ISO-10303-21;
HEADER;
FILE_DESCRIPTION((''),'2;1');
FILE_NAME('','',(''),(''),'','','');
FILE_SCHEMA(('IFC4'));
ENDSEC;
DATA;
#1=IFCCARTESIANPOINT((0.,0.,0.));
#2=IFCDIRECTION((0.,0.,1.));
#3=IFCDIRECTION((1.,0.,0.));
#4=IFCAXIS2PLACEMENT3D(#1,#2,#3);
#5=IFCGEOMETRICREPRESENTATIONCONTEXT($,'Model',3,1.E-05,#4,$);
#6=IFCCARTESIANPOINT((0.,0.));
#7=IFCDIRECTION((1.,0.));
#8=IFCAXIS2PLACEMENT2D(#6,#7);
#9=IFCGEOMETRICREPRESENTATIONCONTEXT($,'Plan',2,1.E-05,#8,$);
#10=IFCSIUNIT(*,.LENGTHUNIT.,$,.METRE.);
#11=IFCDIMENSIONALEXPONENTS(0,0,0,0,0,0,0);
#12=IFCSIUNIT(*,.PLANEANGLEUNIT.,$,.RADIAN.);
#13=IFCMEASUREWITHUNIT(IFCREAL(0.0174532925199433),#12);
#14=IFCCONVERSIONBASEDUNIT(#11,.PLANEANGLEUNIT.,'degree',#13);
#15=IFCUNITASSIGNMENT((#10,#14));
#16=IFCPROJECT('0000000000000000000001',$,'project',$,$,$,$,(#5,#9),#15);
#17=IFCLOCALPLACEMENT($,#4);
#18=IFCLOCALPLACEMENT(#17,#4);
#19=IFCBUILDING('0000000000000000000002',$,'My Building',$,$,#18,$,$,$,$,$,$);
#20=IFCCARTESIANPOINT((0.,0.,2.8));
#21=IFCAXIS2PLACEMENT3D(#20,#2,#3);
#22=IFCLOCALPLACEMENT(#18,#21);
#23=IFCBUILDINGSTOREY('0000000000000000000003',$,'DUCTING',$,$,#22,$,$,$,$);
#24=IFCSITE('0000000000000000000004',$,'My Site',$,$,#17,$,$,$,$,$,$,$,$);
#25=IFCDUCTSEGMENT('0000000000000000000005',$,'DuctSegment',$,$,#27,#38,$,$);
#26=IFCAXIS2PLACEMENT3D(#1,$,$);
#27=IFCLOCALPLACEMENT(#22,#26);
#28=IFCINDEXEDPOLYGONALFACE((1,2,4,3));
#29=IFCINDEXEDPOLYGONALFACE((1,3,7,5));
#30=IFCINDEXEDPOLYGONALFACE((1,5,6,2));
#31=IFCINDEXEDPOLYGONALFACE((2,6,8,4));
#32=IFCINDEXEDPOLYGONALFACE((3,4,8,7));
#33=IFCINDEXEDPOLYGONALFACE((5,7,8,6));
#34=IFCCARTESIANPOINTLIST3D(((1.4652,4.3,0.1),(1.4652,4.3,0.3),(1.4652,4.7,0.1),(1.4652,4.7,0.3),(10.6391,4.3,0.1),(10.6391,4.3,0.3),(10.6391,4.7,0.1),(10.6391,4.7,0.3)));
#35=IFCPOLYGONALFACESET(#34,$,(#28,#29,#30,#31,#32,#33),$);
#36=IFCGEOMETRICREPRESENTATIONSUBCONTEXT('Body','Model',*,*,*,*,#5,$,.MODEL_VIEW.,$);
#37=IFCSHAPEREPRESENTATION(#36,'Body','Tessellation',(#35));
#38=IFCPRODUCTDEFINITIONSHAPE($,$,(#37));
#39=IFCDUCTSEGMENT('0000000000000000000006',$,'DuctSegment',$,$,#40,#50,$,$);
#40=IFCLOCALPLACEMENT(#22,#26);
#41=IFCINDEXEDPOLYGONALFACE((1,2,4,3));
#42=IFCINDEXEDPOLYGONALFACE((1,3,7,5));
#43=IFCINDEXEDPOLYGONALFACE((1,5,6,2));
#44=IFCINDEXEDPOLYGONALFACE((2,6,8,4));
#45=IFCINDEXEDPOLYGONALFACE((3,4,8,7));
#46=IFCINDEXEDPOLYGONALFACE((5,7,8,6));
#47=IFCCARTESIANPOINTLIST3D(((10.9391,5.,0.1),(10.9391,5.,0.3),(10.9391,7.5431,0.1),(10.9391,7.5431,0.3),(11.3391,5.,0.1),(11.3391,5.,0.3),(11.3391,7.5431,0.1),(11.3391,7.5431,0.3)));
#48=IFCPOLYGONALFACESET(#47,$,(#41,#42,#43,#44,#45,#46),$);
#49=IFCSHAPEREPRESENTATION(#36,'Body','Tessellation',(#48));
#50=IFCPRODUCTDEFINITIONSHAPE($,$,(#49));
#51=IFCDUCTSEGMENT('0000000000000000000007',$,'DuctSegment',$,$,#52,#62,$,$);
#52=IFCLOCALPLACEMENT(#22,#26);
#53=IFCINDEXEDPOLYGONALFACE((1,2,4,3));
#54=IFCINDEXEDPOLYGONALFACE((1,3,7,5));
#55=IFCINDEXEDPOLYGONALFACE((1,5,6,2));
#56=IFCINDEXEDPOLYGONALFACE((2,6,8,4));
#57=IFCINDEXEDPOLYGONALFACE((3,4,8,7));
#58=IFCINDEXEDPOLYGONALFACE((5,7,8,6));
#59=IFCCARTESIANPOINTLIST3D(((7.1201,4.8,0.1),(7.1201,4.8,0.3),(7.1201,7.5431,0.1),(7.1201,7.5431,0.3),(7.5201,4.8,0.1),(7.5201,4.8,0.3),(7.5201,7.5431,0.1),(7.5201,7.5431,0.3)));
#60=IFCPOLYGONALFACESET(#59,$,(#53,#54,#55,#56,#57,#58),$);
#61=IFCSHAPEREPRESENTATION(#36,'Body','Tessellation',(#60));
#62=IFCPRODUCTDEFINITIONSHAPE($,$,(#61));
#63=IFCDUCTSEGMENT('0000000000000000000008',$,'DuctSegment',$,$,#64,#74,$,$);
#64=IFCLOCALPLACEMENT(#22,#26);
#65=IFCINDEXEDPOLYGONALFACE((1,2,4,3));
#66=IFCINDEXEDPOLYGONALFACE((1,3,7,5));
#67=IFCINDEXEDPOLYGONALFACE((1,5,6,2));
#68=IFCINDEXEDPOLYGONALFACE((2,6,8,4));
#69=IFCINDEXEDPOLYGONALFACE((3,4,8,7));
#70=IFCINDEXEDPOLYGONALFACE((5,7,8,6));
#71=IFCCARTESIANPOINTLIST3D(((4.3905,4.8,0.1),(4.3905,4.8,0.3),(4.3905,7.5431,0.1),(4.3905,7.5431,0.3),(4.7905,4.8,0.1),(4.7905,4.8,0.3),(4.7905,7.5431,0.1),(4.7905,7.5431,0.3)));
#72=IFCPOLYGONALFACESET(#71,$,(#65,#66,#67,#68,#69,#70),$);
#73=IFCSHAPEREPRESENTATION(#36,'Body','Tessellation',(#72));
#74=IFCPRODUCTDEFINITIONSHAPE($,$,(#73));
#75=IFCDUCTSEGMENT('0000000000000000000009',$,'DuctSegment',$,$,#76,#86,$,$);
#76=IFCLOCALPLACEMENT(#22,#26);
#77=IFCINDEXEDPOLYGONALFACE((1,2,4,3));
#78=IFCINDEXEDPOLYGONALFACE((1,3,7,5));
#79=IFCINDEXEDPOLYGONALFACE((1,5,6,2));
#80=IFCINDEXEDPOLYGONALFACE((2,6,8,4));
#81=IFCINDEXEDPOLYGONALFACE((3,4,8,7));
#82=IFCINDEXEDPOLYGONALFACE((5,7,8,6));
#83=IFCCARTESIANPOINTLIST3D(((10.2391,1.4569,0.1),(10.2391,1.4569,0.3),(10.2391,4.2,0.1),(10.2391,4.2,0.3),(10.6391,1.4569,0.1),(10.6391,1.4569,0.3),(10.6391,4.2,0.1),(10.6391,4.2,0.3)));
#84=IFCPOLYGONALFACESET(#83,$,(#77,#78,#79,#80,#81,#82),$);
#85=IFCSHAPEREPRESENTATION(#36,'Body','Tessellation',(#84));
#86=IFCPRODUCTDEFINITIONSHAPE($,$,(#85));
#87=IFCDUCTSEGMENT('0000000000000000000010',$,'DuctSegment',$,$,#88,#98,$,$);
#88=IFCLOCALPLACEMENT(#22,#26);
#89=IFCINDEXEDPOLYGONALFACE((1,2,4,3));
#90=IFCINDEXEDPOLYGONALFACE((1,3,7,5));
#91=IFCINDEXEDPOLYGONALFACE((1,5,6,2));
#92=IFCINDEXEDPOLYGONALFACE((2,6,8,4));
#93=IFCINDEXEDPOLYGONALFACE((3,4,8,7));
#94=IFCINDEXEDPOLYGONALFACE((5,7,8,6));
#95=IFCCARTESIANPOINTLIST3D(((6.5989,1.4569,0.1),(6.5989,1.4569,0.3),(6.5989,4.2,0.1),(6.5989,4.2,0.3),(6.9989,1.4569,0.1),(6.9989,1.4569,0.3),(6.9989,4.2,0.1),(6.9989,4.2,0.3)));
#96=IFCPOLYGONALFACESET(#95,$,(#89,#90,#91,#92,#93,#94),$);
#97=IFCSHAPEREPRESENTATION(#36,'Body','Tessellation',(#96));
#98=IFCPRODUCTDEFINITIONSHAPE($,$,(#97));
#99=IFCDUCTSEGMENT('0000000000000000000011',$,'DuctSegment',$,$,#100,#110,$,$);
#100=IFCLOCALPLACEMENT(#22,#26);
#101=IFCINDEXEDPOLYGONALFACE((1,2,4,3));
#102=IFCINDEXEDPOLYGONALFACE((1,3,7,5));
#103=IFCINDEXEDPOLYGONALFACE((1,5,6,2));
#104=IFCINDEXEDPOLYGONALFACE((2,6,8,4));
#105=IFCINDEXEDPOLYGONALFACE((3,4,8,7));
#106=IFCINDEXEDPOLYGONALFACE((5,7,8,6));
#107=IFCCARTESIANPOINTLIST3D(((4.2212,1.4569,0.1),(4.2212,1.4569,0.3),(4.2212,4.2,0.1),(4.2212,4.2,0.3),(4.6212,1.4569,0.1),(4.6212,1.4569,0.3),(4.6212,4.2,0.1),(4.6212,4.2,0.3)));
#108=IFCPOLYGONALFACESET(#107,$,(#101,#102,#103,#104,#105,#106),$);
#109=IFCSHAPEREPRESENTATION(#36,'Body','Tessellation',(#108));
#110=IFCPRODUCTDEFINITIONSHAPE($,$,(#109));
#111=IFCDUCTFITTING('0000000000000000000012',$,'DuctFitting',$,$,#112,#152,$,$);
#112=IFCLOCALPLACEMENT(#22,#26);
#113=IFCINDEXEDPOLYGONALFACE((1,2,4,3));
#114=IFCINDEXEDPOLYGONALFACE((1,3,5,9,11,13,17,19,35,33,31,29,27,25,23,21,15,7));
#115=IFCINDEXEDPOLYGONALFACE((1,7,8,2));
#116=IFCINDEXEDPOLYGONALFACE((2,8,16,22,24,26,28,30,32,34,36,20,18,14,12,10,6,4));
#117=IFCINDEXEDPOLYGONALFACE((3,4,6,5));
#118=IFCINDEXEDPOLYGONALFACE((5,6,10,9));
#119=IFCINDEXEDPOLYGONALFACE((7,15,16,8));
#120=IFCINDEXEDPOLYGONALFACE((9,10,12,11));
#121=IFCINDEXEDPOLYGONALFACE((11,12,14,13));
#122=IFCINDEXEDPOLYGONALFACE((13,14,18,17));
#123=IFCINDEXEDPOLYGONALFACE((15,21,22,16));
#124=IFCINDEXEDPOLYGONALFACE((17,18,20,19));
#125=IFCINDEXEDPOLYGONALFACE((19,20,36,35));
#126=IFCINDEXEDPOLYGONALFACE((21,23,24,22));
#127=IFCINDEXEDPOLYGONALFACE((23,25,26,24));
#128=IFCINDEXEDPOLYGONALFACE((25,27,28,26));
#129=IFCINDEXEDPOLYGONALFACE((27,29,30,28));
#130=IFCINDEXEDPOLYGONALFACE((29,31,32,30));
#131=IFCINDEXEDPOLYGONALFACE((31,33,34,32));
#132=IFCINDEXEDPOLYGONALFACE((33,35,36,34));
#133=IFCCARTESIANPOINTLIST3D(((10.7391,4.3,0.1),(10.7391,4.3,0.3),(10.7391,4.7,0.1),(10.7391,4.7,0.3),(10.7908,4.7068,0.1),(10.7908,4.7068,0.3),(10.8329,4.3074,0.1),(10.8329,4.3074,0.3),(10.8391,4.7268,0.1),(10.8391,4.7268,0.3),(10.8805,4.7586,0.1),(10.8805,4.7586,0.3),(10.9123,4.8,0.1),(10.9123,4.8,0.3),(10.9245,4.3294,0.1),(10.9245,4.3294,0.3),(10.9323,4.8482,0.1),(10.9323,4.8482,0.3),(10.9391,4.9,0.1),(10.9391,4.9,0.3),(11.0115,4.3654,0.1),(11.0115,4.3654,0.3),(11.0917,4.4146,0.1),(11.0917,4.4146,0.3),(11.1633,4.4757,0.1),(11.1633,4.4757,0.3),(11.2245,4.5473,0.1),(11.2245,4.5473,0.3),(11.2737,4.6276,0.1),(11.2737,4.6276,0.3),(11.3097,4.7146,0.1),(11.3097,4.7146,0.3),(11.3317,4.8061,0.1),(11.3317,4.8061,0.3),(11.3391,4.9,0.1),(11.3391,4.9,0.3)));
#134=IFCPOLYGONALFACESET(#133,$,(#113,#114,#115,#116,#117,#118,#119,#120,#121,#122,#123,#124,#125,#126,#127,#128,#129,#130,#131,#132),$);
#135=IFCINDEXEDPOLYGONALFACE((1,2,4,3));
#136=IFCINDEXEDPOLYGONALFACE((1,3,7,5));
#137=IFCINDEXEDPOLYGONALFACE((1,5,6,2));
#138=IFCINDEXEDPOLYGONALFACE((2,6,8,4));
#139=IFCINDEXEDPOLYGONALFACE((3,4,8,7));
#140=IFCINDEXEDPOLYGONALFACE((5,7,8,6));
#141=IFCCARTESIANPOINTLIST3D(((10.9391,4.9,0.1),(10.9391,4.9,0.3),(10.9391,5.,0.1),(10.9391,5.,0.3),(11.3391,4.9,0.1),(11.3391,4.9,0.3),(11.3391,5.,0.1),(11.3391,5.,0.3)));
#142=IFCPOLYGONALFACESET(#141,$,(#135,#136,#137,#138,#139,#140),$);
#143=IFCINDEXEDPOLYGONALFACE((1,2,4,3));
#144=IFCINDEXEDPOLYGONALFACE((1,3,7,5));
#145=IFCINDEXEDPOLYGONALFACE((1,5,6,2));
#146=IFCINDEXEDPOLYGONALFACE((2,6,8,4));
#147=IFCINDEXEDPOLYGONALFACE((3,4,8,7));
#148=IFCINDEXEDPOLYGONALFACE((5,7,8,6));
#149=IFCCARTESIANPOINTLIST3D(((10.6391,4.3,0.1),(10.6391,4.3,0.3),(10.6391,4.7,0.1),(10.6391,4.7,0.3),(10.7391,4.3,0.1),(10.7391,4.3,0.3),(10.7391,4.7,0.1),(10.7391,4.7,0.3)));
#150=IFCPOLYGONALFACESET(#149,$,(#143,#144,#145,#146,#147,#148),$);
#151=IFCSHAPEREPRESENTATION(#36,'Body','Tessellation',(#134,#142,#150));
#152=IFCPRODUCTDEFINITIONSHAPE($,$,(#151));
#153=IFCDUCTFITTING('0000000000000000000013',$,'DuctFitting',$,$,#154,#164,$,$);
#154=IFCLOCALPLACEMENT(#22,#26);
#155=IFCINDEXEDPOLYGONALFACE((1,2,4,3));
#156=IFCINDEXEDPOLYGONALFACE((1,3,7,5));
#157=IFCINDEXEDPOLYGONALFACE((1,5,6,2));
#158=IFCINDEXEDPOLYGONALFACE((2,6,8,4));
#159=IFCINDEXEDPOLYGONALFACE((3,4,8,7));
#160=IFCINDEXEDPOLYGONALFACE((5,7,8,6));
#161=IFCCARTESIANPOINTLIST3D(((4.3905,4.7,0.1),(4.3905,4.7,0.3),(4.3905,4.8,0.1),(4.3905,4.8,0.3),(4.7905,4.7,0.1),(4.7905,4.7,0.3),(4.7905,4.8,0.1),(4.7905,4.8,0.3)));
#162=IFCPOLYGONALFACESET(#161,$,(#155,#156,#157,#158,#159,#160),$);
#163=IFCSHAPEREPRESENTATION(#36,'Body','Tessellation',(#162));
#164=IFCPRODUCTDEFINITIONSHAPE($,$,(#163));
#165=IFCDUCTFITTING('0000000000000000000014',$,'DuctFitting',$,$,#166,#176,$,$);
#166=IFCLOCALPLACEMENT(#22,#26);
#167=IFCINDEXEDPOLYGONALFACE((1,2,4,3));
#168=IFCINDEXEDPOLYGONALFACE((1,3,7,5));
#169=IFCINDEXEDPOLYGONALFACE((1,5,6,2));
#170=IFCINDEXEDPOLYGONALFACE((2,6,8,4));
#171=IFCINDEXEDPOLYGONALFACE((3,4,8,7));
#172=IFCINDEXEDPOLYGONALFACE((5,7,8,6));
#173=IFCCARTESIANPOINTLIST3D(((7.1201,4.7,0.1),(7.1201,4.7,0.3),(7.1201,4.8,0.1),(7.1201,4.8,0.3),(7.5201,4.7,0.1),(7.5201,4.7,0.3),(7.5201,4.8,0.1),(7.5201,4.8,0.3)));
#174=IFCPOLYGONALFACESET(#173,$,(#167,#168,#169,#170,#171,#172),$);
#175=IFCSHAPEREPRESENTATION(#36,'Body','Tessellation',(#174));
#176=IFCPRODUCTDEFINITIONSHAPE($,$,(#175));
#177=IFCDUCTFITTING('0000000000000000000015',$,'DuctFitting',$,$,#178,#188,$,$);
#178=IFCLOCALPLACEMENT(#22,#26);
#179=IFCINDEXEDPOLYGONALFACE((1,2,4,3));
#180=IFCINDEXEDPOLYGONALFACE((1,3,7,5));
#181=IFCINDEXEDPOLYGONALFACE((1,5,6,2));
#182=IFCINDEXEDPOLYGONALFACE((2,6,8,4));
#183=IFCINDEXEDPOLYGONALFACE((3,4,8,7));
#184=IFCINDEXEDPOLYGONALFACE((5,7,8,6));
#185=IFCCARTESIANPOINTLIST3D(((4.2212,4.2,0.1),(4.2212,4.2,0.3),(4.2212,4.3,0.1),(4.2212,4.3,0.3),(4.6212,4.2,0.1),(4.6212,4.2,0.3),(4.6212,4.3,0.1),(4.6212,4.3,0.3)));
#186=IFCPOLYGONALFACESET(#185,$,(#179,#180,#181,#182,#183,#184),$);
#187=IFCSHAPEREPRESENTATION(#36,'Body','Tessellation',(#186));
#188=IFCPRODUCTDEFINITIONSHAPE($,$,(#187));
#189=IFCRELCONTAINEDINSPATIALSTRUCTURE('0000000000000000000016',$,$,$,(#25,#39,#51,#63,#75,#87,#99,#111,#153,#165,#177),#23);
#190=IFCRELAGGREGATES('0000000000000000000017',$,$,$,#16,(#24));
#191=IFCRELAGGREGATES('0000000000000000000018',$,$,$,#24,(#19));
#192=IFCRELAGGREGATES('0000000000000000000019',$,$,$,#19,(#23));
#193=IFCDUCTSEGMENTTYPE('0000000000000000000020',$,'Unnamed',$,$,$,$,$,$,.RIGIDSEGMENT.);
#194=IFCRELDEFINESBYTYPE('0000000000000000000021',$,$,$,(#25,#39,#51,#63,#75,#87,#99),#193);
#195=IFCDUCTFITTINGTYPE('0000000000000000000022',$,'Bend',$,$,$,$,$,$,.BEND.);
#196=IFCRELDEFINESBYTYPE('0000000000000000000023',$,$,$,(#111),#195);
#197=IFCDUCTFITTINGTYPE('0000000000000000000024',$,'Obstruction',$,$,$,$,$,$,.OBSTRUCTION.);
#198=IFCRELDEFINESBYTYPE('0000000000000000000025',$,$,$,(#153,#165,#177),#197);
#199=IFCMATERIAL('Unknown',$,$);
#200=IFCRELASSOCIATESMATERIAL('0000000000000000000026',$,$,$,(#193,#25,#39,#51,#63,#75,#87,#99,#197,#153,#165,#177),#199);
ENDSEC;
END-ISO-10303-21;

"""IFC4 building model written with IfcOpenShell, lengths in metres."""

from ifc_helpers import new_model, entity, si_unit, converted_unit, frame, origin_with_axes, origin_2d_with_axis, place, context, subcontext, project, spatial, line, arc, indexed_curve, rectangle, outline, extrude, source, transform, mapped, material, material_profile, profile_set, profile_usage, type_object, type_shapes, element, save


model = new_model("IFC4")

# Units and contexts
model_context = context("Model", 3, precision=1e-05, world=origin_with_axes())
plan_context = context("Plan", 2, precision=1e-05, world=origin_2d_with_axis())
body_context = subcontext(model_context, "Body", "Model", "MODEL_VIEW")
ifc_project = project(units=[si_unit("LENGTHUNIT", "METRE"), converted_unit("PLANEANGLEUNIT", "degree", entity("IfcReal", 0.0174532925199433), si_unit("PLANEANGLEUNIT", "RADIAN"), dimensions=[0, 0, 0, 0, 0, 0, 0])], contexts=[model_context, plan_context])

# Site, building, storey
site_placement = place(None, origin_with_axes())
site = spatial("IfcSite", under=ifc_project, at=site_placement, Name="My Site")
building_placement = place(site_placement, origin_with_axes())
building = spatial("IfcBuilding", under=site, at=building_placement, Name="My Building")
storey_placement = place(building_placement, frame((0.0, 0.0, 2.8), z_axis=(0.0, 0.0, 1.0), x_axis=(1.0, 0.0, 0.0)))
storey = spatial("IfcBuildingStorey", under=building, at=storey_placement, Name="DUCTING")

# Duct segments
ifc_material = material(Name="Unknown")
ifc_material_profile_1 = material_profile(ifc_material, rectangle(XDim=0.4, YDim=0.2))
ifc_profile_set_1 = profile_set([ifc_material_profile_1])
ifc_profile_usage_1 = profile_usage(ifc_profile_set_1, cardinal=5)
duct_segment_type = type_object("IfcDuctSegmentType", Name="Unnamed", PredefinedType="RIGIDSEGMENT", material=ifc_profile_set_1)
duct_segment_1_placement = place(storey_placement, frame((1.4652, 4.5, 0.2), z_axis=(1.0, 0.0, 0.0), x_axis=(0.0, 1.0, 0.0)))
element("IfcDuctSegment", 1, at=duct_segment_1_placement, inside=storey, type_object=duct_segment_type, material=ifc_profile_usage_1, Name="DuctSegment", context=body_context, shape_type="SweptSolid", body=[
    extrude(rectangle(XDim=0.4, YDim=0.2), origin_with_axes(), (0.0, 0.0, 1.0), 9.1739),
])
ifc_profile_usage_2 = profile_usage(ifc_profile_set_1, cardinal=5)
duct_segment_2_placement = place(storey_placement, frame((11.1391, 5.0, 0.2), z_axis=(0.0, 1.0, 0.0), x_axis=(-1.0, 0.0, 0.0)))
element("IfcDuctSegment", 2, at=duct_segment_2_placement, inside=storey, type_object=duct_segment_type, material=ifc_profile_usage_2, Name="DuctSegment", context=body_context, shape_type="SweptSolid", body=[
    extrude(rectangle(XDim=0.4, YDim=0.2), origin_with_axes(), (0.0, 0.0, 1.0), 2.5431),
])
ifc_profile_usage_3 = profile_usage(ifc_profile_set_1, cardinal=5)
duct_segment_3_placement = place(storey_placement, frame((7.3201, 4.8, 0.2), z_axis=(0.0, 1.0, 0.0), x_axis=(-1.0, 0.0, 0.0)))
element("IfcDuctSegment", 3, at=duct_segment_3_placement, inside=storey, type_object=duct_segment_type, material=ifc_profile_usage_3, Name="DuctSegment", context=body_context, shape_type="SweptSolid", body=[
    extrude(rectangle(XDim=0.4, YDim=0.2), origin_with_axes(), (0.0, 0.0, 1.0), 2.7431),
])
ifc_profile_usage_4 = profile_usage(ifc_profile_set_1, cardinal=5)
duct_segment_4_placement = place(storey_placement, frame((4.5905, 4.8, 0.2), z_axis=(0.0, 1.0, 0.0), x_axis=(-1.0, 0.0, 0.0)))
element("IfcDuctSegment", 4, at=duct_segment_4_placement, inside=storey, type_object=duct_segment_type, material=ifc_profile_usage_4, Name="DuctSegment", context=body_context, shape_type="SweptSolid", body=[
    extrude(rectangle(XDim=0.4, YDim=0.2), origin_with_axes(), (0.0, 0.0, 1.0), 2.7431),
])
ifc_profile_usage_5 = profile_usage(ifc_profile_set_1, cardinal=5)
duct_segment_5_placement = place(storey_placement, frame((10.4391, 4.2, 0.2), z_axis=(0.0, -1.0, 0.0), x_axis=(1.0, 0.0, 0.0)))
element("IfcDuctSegment", 5, at=duct_segment_5_placement, inside=storey, type_object=duct_segment_type, material=ifc_profile_usage_5, Name="DuctSegment", context=body_context, shape_type="SweptSolid", body=[
    extrude(rectangle(XDim=0.4, YDim=0.2), origin_with_axes(), (0.0, 0.0, 1.0), 2.7431),
])
ifc_profile_usage_6 = profile_usage(ifc_profile_set_1, cardinal=5)
duct_segment_6_placement = place(storey_placement, frame((6.7989, 4.2, 0.2), z_axis=(0.0, -1.0, 0.0), x_axis=(1.0, 0.0, 0.0)))
element("IfcDuctSegment", 6, at=duct_segment_6_placement, inside=storey, type_object=duct_segment_type, material=ifc_profile_usage_6, Name="DuctSegment", context=body_context, shape_type="SweptSolid", body=[
    extrude(rectangle(XDim=0.4, YDim=0.2), origin_with_axes(), (0.0, 0.0, 1.0), 2.7431),
])
ifc_profile_usage_7 = profile_usage(ifc_profile_set_1, cardinal=5)
duct_segment_7_placement = place(storey_placement, frame((4.4212, 4.2, 0.2), z_axis=(0.0, -1.0, 0.0), x_axis=(1.0, 0.0, 0.0)))
element("IfcDuctSegment", 7, at=duct_segment_7_placement, inside=storey, type_object=duct_segment_type, material=ifc_profile_usage_7, Name="DuctSegment", context=body_context, shape_type="SweptSolid", body=[
    extrude(rectangle(XDim=0.4, YDim=0.2), origin_with_axes(), (0.0, 0.0, 1.0), 2.7431),
])

# Duct fittings
duct_fitting_type_1 = type_object("IfcDuctFittingType", Name="Bend", PredefinedType="BEND")
shared_shape = source(origin_with_axes(), body_context, "Body", "SweptSolid", [
    extrude(outline(indexed_curve([(0.2, 0.0), (0.2586, -0.1414), (0.4, -0.2), (0.4, -0.6), (-0.0243, -0.4243), (-0.2, 0.0)], segments=[arc(1, 2, 3), line(3, 4), arc(4, 5, 6), line(6, 1)])), frame((0.0, -0.1, -0.1), z_axis=(0.0, -1.0, 0.0), x_axis=(1.0, 0.0, 0.0)), (0.0, 0.0, -1.0), 0.2),
    extrude(rectangle(XDim=0.4, YDim=0.2), origin_with_axes(), (0.0, 0.0, -1.0), 0.1),
    extrude(rectangle(XDim=0.4, YDim=0.2), frame((0.4, 0.0, -0.5), z_axis=(1.0, 0.0, 0.0), x_axis=(0.0, 0.0, 1.0)), (0.0, 0.0, 1.0), 0.1),
])
type_shapes(duct_fitting_type_1, [shared_shape])
duct_fitting_1_placement = place(storey_placement, frame((11.1391, 5.0, 0.2), z_axis=(0.0, 1.0, 0.0), x_axis=(-1.0, 0.0, 0.0)))
element("IfcDuctFitting", 8, at=duct_fitting_1_placement, inside=storey, type_object=duct_fitting_type_1, Name="DuctFitting", context=body_context, shape_type="MappedRepresentation", body=[
    mapped(shared_shape, transform((0.0, 0.0, 0.0), x_axis=(1.0, 0.0, 0.0), y_axis=(0.0, 1.0, 0.0), z_axis=(0.0, 0.0, 1.0), scale=1.0)),
])
ifc_material_profile_2 = material_profile(ifc_material, rectangle(XDim=0.4, YDim=0.2))
ifc_profile_set_2 = profile_set([ifc_material_profile_2])
ifc_profile_usage_8 = profile_usage(ifc_profile_set_2, cardinal=5)
duct_fitting_type_2 = type_object("IfcDuctFittingType", Name="Obstruction", PredefinedType="OBSTRUCTION", material=ifc_profile_set_2)
duct_fitting_2_placement = place(storey_placement, frame((4.5905, 4.7, 0.2), z_axis=(0.0, 1.0, 0.0), x_axis=(-1.0, 0.0, 0.0)))
element("IfcDuctFitting", 9, at=duct_fitting_2_placement, inside=storey, type_object=duct_fitting_type_2, material=ifc_profile_usage_8, Name="DuctFitting", context=body_context, shape_type="SweptSolid", body=[
    extrude(rectangle(XDim=0.4, YDim=0.2), origin_with_axes(), (0.0, 0.0, 1.0), 0.1),
])
ifc_profile_usage_9 = profile_usage(ifc_profile_set_2, cardinal=5)
duct_fitting_3_placement = place(storey_placement, frame((7.3201, 4.7, 0.2), z_axis=(0.0, 1.0, 0.0), x_axis=(-1.0, 0.0, 0.0)))
element("IfcDuctFitting", 10, at=duct_fitting_3_placement, inside=storey, type_object=duct_fitting_type_2, material=ifc_profile_usage_9, Name="DuctFitting", context=body_context, shape_type="SweptSolid", body=[
    extrude(rectangle(XDim=0.4, YDim=0.2), origin_with_axes(), (0.0, 0.0, 1.0), 0.1),
])
ifc_profile_usage_10 = profile_usage(ifc_profile_set_2, cardinal=5)
duct_fitting_4_placement = place(storey_placement, frame((4.4212, 4.3, 0.2), z_axis=(0.0, -1.0, 0.0), x_axis=(1.0, 0.0, 0.0)))
element("IfcDuctFitting", 11, at=duct_fitting_4_placement, inside=storey, type_object=duct_fitting_type_2, material=ifc_profile_usage_10, Name="DuctFitting", context=body_context, shape_type="SweptSolid", body=[
    extrude(rectangle(XDim=0.4, YDim=0.2), origin_with_axes(), (0.0, 0.0, 1.0), 0.1),
])

save(model, "model.ifc")
